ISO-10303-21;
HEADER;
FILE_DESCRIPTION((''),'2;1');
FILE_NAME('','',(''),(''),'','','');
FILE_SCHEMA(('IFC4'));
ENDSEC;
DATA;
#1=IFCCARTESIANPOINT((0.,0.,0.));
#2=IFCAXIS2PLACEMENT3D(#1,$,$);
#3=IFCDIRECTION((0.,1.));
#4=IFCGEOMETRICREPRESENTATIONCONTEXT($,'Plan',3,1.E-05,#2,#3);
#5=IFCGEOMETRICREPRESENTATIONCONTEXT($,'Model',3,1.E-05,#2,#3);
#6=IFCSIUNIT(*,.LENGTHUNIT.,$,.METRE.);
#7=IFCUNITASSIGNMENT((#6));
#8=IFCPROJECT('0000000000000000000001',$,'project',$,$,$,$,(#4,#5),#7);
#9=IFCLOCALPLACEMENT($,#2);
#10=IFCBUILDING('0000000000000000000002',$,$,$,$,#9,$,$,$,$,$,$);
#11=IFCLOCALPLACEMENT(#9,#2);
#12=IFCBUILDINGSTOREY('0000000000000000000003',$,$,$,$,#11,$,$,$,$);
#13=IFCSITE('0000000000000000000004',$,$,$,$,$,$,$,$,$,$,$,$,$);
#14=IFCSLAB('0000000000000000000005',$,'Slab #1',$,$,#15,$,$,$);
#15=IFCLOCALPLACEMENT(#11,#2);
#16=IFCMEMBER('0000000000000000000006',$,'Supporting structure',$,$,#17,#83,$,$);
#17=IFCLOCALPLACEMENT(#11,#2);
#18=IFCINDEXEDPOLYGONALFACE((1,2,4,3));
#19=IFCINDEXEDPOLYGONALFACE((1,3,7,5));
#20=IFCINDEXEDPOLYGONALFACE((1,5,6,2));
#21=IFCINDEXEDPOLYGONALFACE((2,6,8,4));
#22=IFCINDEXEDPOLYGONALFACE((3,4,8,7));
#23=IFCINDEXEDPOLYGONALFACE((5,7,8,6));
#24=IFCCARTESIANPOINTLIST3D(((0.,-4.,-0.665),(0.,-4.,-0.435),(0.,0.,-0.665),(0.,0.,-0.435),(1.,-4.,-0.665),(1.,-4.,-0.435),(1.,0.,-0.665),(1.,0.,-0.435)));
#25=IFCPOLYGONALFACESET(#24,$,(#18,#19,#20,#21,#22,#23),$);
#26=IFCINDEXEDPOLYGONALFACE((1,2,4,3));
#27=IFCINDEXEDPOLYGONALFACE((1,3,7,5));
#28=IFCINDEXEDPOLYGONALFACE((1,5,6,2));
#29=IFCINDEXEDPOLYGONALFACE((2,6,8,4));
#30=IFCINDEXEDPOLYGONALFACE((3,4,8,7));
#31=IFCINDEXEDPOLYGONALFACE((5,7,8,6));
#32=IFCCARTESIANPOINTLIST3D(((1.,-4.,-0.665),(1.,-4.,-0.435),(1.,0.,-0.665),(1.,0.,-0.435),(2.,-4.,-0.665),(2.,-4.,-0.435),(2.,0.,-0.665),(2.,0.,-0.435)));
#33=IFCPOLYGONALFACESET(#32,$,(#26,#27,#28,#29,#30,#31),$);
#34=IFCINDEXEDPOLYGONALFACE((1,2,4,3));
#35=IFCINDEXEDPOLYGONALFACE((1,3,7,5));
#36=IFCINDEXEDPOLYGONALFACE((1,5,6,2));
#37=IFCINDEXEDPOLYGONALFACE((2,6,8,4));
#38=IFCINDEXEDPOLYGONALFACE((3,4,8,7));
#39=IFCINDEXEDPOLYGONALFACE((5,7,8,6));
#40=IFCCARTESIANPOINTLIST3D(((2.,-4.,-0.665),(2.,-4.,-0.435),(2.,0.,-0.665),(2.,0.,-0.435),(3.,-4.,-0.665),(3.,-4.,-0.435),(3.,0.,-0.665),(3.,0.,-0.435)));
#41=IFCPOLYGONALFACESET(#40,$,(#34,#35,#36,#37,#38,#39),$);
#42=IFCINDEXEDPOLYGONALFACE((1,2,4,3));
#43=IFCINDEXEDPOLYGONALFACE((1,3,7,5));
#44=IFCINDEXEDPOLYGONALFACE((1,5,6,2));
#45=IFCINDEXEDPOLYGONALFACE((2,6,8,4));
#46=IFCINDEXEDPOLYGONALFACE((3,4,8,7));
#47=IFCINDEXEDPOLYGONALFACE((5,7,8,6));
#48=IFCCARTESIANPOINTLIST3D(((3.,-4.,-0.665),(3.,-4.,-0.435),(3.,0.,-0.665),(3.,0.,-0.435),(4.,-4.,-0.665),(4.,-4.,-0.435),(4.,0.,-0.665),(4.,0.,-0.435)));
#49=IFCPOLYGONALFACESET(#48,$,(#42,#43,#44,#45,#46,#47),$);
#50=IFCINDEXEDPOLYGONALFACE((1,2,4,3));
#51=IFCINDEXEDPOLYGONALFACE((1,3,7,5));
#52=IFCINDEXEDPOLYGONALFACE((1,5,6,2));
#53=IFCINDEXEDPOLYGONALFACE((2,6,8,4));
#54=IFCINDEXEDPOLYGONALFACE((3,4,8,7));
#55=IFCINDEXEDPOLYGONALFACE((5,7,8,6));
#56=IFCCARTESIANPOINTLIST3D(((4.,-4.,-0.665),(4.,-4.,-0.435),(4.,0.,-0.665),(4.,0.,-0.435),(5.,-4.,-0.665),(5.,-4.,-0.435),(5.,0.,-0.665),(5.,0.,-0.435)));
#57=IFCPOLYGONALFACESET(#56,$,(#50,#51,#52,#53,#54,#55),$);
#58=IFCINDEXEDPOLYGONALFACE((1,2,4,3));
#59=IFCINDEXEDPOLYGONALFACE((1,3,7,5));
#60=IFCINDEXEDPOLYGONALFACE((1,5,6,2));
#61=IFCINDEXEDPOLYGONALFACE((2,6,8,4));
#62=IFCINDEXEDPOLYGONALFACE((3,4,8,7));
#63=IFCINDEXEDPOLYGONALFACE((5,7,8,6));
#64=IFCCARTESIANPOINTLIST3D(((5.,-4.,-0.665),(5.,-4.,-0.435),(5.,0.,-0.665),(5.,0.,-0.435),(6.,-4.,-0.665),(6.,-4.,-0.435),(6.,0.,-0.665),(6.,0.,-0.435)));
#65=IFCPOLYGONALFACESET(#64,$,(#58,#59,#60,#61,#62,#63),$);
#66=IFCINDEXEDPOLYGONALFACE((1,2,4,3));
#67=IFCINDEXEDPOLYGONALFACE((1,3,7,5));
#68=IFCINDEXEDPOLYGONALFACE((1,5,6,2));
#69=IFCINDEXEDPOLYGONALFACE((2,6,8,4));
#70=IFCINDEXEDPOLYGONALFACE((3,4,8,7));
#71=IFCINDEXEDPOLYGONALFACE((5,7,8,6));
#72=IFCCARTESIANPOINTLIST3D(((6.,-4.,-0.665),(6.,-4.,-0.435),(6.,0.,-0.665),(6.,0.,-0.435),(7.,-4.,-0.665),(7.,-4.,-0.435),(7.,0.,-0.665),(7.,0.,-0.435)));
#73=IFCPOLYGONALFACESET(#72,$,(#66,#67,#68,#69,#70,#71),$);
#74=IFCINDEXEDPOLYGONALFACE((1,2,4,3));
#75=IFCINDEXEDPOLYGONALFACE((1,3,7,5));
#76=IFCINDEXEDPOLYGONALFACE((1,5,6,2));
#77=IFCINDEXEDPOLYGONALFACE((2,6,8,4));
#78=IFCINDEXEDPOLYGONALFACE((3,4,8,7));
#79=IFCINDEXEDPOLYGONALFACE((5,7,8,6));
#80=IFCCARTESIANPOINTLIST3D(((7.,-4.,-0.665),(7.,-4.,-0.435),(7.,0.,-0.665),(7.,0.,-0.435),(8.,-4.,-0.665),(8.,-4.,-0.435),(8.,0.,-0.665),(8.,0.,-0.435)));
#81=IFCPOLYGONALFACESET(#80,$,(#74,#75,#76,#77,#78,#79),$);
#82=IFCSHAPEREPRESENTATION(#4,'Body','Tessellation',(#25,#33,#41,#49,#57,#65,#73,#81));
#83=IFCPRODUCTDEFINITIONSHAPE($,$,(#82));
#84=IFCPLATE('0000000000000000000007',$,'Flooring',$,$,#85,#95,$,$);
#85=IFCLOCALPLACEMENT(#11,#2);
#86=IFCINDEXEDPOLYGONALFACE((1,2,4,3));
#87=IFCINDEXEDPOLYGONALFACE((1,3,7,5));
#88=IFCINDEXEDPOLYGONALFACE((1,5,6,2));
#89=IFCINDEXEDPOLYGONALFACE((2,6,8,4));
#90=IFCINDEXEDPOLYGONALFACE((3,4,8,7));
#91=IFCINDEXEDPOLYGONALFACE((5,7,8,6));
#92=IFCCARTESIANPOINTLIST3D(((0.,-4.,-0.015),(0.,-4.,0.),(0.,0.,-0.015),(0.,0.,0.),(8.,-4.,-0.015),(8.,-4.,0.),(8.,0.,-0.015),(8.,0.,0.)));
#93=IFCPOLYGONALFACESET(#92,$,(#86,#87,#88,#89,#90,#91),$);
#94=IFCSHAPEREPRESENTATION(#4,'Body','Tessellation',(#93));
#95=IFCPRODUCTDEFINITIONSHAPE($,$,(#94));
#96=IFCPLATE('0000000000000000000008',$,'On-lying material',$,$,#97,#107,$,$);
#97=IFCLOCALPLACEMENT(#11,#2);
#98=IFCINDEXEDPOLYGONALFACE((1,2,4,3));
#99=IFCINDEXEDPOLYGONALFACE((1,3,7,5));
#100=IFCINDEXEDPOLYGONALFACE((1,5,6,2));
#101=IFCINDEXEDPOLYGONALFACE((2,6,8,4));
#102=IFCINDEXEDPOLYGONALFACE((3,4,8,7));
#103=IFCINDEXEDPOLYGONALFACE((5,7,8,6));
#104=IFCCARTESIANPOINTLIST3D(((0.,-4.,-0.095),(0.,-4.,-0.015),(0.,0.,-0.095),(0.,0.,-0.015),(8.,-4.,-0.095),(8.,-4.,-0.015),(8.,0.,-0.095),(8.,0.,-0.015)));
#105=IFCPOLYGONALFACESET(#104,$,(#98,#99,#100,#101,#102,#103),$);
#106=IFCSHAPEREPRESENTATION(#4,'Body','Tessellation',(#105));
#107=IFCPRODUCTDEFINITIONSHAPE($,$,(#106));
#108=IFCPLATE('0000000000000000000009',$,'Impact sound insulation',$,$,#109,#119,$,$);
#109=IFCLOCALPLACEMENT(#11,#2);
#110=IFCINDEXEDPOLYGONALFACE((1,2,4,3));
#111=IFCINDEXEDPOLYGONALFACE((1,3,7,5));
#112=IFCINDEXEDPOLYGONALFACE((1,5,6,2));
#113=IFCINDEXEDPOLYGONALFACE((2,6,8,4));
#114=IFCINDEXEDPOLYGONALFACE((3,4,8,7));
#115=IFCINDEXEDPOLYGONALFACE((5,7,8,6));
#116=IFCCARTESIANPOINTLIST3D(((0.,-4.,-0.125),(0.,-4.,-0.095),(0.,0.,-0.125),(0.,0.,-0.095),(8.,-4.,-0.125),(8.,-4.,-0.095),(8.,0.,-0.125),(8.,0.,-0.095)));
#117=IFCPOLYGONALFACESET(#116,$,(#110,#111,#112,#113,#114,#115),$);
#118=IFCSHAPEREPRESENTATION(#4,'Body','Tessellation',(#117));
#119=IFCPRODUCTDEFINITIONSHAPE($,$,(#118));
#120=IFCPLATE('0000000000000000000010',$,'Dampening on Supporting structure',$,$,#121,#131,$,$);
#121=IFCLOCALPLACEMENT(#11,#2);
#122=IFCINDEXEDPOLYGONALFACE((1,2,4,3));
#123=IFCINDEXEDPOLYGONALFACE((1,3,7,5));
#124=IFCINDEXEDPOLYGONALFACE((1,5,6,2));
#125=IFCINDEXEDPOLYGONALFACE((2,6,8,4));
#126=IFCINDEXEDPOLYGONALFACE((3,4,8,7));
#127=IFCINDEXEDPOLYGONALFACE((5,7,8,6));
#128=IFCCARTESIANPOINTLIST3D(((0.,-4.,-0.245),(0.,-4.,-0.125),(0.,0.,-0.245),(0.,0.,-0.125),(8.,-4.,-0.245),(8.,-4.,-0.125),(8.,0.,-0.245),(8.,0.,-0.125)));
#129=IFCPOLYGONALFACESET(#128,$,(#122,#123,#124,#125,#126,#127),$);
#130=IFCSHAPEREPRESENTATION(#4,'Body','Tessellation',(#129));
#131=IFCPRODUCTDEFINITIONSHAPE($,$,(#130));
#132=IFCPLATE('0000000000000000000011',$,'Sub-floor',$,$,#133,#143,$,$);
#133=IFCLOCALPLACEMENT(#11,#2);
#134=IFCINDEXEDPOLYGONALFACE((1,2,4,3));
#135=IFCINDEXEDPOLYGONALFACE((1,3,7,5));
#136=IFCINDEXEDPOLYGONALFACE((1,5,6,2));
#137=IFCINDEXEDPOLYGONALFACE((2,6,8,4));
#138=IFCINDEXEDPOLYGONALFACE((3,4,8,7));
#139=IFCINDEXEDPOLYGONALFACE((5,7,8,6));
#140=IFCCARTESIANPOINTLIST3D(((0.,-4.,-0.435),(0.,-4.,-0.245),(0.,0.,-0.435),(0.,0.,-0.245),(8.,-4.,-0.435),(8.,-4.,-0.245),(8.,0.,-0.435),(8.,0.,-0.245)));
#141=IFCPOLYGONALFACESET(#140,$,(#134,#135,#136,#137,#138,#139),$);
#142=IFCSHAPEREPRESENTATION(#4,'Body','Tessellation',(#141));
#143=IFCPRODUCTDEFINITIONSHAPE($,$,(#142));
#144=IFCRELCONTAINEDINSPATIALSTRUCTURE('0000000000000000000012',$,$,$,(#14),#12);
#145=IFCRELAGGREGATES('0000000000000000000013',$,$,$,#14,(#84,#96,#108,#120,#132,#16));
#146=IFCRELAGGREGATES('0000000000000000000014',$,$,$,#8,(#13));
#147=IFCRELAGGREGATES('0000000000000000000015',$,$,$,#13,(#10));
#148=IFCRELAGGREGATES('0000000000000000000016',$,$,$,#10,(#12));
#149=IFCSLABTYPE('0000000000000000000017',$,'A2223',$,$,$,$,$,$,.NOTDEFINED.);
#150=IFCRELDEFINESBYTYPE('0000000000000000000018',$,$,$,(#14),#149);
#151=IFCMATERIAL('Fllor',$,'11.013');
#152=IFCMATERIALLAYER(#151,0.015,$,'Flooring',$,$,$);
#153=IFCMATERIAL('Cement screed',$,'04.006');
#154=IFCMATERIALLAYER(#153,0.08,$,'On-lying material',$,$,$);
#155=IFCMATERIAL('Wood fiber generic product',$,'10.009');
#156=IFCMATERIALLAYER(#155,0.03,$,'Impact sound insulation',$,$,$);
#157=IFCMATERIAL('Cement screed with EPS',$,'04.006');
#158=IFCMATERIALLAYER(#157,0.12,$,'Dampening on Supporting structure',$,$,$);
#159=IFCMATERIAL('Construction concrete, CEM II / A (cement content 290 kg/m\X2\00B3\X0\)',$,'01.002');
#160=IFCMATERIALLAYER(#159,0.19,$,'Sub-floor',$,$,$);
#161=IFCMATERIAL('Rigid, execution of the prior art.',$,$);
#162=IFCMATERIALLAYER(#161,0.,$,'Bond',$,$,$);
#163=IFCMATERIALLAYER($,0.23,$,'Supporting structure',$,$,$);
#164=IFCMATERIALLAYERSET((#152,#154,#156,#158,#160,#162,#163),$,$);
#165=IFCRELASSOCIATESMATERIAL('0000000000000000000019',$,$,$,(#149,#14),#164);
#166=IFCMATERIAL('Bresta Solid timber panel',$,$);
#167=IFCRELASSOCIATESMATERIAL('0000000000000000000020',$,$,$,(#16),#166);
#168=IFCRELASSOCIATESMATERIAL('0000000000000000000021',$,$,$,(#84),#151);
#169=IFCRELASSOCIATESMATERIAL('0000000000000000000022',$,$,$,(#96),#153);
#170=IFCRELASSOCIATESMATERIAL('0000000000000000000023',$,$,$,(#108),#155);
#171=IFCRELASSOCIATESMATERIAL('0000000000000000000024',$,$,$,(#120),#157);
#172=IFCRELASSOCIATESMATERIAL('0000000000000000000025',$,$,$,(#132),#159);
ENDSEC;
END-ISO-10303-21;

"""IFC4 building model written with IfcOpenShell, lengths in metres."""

from ifc_helpers import new_model, si_unit, direction, frame, frame_2d, origin, origin_with_axes, place, context, project, spatial, rectangle, extrude, material, layer, layer_set, type_object, element, aggregate, save


model = new_model("IFC4")

# Units and contexts
plan_context = context("Plan", 3, precision=1e-05, world=origin(), true_north=direction((0.0, 1.0)))
model_context = context("Model", 3, precision=1e-05, world=origin(), true_north=direction((0.0, 1.0)))
ifc_project = project(units=[si_unit("LENGTHUNIT", "METRE")], contexts=[plan_context, model_context])

# Site, building, storey
site = spatial("IfcSite", under=ifc_project)
building_placement = place(None, origin())
building = spatial("IfcBuilding", under=site, at=building_placement)
storey_placement = place(building_placement, origin())
storey = spatial("IfcBuildingStorey", under=building, at=storey_placement)

# Slab, member, plates
ifc_material_1 = material(Name="Fllor", Category="11.013")
ifc_layer_1 = layer(ifc_material_1, 0.015, Name="Flooring")
ifc_material_2 = material(Name="Cement screed", Category="04.006")
ifc_layer_2 = layer(ifc_material_2, 0.08, Name="On-lying material")
ifc_material_3 = material(Name="Wood fiber generic product", Category="10.009")
ifc_layer_3 = layer(ifc_material_3, 0.03, Name="Impact sound insulation")
ifc_material_4 = material(Name="Cement screed with EPS", Category="04.006")
ifc_layer_4 = layer(ifc_material_4, 0.12, Name="Dampening on Supporting structure")
ifc_material_5 = material(Name="Construction concrete, CEM II / A (cement content 290 kg/m³)", Category="01.002")
ifc_layer_5 = layer(ifc_material_5, 0.19, Name="Sub-floor")
ifc_material_6 = material(Name="Rigid, execution of the prior art.")
ifc_layer_6 = layer(ifc_material_6, 0.0, Name="Bond")
ifc_layer_7 = layer(None, 0.23, Name="Supporting structure")
ifc_layer_set = layer_set([ifc_layer_1, ifc_layer_2, ifc_layer_3, ifc_layer_4, ifc_layer_5, ifc_layer_6, ifc_layer_7])
slab_type = type_object("IfcSlabType", Name="A2223", PredefinedType="NOTDEFINED", material=ifc_layer_set)
slab_placement = place(None, frame((0.0, 0.0, 0.0), z_axis=(0.0, 0.0, -1.0), x_axis=(1.0, 0.0, 0.0)))
slab = element("IfcSlab", 1, at=slab_placement, inside=storey, type_object=slab_type, material=ifc_layer_set, Name="Slab #1")
ifc_material_7 = material(Name="Bresta Solid timber panel")
member_placement = place(slab_placement, origin())
member = element("IfcMember", 2, at=member_placement, material=ifc_material_7, Name="Supporting structure", context=plan_context, shape_type="SweptSolid", body=[
    extrude(rectangle(XDim=1.0, YDim=0.23, at=frame_2d((0.5, 0.115), x_axis=(1.0, 0.0))), frame((0.0, 4.0, 0.435), z_axis=(0.0, -1.0, 0.0), x_axis=(1.0, 0.0, 0.0)), (0.0, 0.0, 1.0), 4.0),
    extrude(rectangle(XDim=1.0, YDim=0.23, at=frame_2d((0.5, 0.115), x_axis=(1.0, 0.0))), frame((1.0, 4.0, 0.435), z_axis=(0.0, -1.0, 0.0), x_axis=(1.0, 0.0, 0.0)), (0.0, 0.0, 1.0), 4.0),
    extrude(rectangle(XDim=1.0, YDim=0.23, at=frame_2d((0.5, 0.115), x_axis=(1.0, 0.0))), frame((2.0, 4.0, 0.435), z_axis=(0.0, -1.0, 0.0), x_axis=(1.0, 0.0, 0.0)), (0.0, 0.0, 1.0), 4.0),
    extrude(rectangle(XDim=1.0, YDim=0.23, at=frame_2d((0.5, 0.115), x_axis=(1.0, 0.0))), frame((3.0, 4.0, 0.435), z_axis=(0.0, -1.0, 0.0), x_axis=(1.0, 0.0, 0.0)), (0.0, 0.0, 1.0), 4.0),
    extrude(rectangle(XDim=1.0, YDim=0.23, at=frame_2d((0.5, 0.115), x_axis=(1.0, 0.0))), frame((4.0, 4.0, 0.435), z_axis=(0.0, -1.0, 0.0), x_axis=(1.0, 0.0, 0.0)), (0.0, 0.0, 1.0), 4.0),
    extrude(rectangle(XDim=1.0, YDim=0.23, at=frame_2d((0.5, 0.115), x_axis=(1.0, 0.0))), frame((5.0, 4.0, 0.435), z_axis=(0.0, -1.0, 0.0), x_axis=(1.0, 0.0, 0.0)), (0.0, 0.0, 1.0), 4.0),
    extrude(rectangle(XDim=1.0, YDim=0.23, at=frame_2d((0.5, 0.115), x_axis=(1.0, 0.0))), frame((6.0, 4.0, 0.435), z_axis=(0.0, -1.0, 0.0), x_axis=(1.0, 0.0, 0.0)), (0.0, 0.0, 1.0), 4.0),
    extrude(rectangle(XDim=1.0, YDim=0.23, at=frame_2d((0.5, 0.115), x_axis=(1.0, 0.0))), frame((7.0, 4.0, 0.435), z_axis=(0.0, -1.0, 0.0), x_axis=(1.0, 0.0, 0.0)), (0.0, 0.0, 1.0), 4.0),
])
plate_1_placement = place(slab_placement, origin())
plate_1 = element("IfcPlate", 3, at=plate_1_placement, material=ifc_material_1, Name="Flooring", context=plan_context, shape_type="SweptSolid", body=[
    extrude(rectangle(XDim=8.0, YDim=4.0, at=frame_2d((4.0, 2.0), x_axis=(1.0, 0.0))), origin_with_axes(), (0.0, 0.0, 1.0), 0.015),
])
plate_2_placement = place(slab_placement, origin())
plate_2 = element("IfcPlate", 4, at=plate_2_placement, material=ifc_material_2, Name="On-lying material", context=plan_context, shape_type="SweptSolid", body=[
    extrude(rectangle(XDim=8.0, YDim=4.0, at=frame_2d((4.0, 2.0), x_axis=(1.0, 0.0))), frame((0.0, 0.0, 0.015), z_axis=(0.0, 0.0, 1.0), x_axis=(1.0, 0.0, 0.0)), (0.0, 0.0, 1.0), 0.08),
])
plate_3_placement = place(slab_placement, origin())
plate_3 = element("IfcPlate", 5, at=plate_3_placement, material=ifc_material_3, Name="Impact sound insulation", context=plan_context, shape_type="SweptSolid", body=[
    extrude(rectangle(XDim=8.0, YDim=4.0, at=frame_2d((4.0, 2.0), x_axis=(1.0, 0.0))), frame((0.0, 0.0, 0.095), z_axis=(0.0, 0.0, 1.0), x_axis=(1.0, 0.0, 0.0)), (0.0, 0.0, 1.0), 0.03),
])
plate_4_placement = place(slab_placement, origin())
plate_4 = element("IfcPlate", 6, at=plate_4_placement, material=ifc_material_4, Name="Dampening on Supporting structure", context=plan_context, shape_type="SweptSolid", body=[
    extrude(rectangle(XDim=8.0, YDim=4.0, at=frame_2d((4.0, 2.0), x_axis=(1.0, 0.0))), frame((0.0, 0.0, 0.125), z_axis=(0.0, 0.0, 1.0), x_axis=(1.0, 0.0, 0.0)), (0.0, 0.0, 1.0), 0.12),
])
plate_5_placement = place(slab_placement, origin())
plate_5 = element("IfcPlate", 7, at=plate_5_placement, material=ifc_material_5, Name="Sub-floor", context=plan_context, shape_type="SweptSolid", body=[
    extrude(rectangle(XDim=8.0, YDim=4.0, at=frame_2d((4.0, 2.0), x_axis=(1.0, 0.0))), frame((0.0, 0.0, 0.245), z_axis=(0.0, 0.0, 1.0), x_axis=(1.0, 0.0, 0.0)), (0.0, 0.0, 1.0), 0.19),
])
aggregate(slab, [plate_1, plate_2, plate_3, plate_4, plate_5, member])

save(model, "model.ifc")
